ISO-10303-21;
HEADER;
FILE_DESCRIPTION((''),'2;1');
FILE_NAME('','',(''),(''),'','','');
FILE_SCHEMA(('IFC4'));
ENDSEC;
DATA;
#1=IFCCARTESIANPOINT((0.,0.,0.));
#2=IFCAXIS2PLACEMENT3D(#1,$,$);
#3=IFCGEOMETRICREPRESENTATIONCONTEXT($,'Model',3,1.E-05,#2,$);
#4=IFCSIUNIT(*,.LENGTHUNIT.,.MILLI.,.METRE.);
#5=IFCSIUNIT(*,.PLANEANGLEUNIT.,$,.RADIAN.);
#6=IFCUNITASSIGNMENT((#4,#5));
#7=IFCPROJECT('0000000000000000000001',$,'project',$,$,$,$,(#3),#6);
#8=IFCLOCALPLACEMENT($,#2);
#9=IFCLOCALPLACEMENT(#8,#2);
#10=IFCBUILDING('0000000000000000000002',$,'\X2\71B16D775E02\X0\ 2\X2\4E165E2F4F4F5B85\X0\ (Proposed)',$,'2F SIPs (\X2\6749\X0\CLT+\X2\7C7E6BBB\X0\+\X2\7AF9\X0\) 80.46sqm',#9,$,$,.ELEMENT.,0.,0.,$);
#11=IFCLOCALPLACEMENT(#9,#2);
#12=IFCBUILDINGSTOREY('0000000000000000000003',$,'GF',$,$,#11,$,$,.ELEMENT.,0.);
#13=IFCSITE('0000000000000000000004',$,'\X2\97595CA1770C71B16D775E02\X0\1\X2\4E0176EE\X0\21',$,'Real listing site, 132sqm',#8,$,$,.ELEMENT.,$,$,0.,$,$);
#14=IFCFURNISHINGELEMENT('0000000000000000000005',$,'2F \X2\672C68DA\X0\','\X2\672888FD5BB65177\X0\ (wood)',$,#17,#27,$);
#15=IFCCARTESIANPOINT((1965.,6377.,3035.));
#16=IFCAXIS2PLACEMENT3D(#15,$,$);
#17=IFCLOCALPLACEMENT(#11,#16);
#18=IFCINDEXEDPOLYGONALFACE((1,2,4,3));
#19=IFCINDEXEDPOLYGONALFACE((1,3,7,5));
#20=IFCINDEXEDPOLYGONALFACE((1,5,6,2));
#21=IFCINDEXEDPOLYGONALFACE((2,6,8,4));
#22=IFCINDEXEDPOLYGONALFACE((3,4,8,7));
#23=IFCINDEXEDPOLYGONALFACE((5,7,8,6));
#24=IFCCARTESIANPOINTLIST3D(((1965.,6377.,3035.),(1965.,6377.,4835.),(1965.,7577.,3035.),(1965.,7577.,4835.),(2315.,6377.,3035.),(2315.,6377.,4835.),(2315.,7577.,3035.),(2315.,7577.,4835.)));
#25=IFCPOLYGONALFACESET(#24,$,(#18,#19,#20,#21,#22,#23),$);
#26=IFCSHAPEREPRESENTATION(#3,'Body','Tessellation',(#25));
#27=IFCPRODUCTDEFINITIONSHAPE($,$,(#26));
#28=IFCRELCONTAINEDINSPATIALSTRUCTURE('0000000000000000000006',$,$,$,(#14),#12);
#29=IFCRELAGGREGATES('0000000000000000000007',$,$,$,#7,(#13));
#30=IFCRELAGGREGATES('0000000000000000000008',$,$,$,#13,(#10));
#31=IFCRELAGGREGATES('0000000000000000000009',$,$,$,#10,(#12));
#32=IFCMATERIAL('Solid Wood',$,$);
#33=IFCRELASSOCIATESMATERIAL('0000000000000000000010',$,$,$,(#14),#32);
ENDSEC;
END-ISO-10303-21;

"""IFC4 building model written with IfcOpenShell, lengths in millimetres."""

from ifc_helpers import new_model, si_unit, frame, frame_2d, origin, place, context, project, spatial, rectangle, extrude, material, element, save


model = new_model("IFC4")

# Units and contexts
model_context = context("Model", 3, precision=1e-05, world=origin())
ifc_project = project(units=[si_unit("LENGTHUNIT", "METRE", prefix="MILLI"), si_unit("PLANEANGLEUNIT", "RADIAN")], contexts=[model_context])

# Site, building, storey
site_placement = place(None, origin())
site = spatial("IfcSite", under=ifc_project, at=site_placement, Name="静岡県熱海市1丁目21", ObjectType="Real listing site, 132sqm", CompositionType="ELEMENT", RefElevation=0.0)
building_placement = place(site_placement, origin())
building = spatial("IfcBuilding", under=site, at=building_placement, Name="熱海市 2世帯住宅 (Proposed)", ObjectType="2F SIPs (杉CLT+籾殻+竹) 80.46sqm", CompositionType="ELEMENT", ElevationOfRefHeight=0.0, ElevationOfTerrain=0.0)
storey_placement = place(building_placement, origin())
storey = spatial("IfcBuildingStorey", under=building, at=storey_placement, Name="GF", CompositionType="ELEMENT", Elevation=0.0)

# Shared definitions
ifc_material_1 = material(Name="Solid Wood")

# Furnishing element
furnishing_placement = place(storey_placement, frame((1965.0, 6377.0, 3035.0)))
element("IfcFurnishingElement", 1, at=furnishing_placement, inside=storey, material=ifc_material_1, Name="2F 本棚", Description="木製家具 (wood)", context=model_context, shape_type="SweptSolid", body=[
    extrude(rectangle(XDim=350.0, YDim=1200.0, at=frame_2d((175.0, 600.0))), frame((1965.0, 6377.0, 3035.0)), (0.0, 0.0, 1.0), 1800.0),
])

save(model, "model.ifc")
